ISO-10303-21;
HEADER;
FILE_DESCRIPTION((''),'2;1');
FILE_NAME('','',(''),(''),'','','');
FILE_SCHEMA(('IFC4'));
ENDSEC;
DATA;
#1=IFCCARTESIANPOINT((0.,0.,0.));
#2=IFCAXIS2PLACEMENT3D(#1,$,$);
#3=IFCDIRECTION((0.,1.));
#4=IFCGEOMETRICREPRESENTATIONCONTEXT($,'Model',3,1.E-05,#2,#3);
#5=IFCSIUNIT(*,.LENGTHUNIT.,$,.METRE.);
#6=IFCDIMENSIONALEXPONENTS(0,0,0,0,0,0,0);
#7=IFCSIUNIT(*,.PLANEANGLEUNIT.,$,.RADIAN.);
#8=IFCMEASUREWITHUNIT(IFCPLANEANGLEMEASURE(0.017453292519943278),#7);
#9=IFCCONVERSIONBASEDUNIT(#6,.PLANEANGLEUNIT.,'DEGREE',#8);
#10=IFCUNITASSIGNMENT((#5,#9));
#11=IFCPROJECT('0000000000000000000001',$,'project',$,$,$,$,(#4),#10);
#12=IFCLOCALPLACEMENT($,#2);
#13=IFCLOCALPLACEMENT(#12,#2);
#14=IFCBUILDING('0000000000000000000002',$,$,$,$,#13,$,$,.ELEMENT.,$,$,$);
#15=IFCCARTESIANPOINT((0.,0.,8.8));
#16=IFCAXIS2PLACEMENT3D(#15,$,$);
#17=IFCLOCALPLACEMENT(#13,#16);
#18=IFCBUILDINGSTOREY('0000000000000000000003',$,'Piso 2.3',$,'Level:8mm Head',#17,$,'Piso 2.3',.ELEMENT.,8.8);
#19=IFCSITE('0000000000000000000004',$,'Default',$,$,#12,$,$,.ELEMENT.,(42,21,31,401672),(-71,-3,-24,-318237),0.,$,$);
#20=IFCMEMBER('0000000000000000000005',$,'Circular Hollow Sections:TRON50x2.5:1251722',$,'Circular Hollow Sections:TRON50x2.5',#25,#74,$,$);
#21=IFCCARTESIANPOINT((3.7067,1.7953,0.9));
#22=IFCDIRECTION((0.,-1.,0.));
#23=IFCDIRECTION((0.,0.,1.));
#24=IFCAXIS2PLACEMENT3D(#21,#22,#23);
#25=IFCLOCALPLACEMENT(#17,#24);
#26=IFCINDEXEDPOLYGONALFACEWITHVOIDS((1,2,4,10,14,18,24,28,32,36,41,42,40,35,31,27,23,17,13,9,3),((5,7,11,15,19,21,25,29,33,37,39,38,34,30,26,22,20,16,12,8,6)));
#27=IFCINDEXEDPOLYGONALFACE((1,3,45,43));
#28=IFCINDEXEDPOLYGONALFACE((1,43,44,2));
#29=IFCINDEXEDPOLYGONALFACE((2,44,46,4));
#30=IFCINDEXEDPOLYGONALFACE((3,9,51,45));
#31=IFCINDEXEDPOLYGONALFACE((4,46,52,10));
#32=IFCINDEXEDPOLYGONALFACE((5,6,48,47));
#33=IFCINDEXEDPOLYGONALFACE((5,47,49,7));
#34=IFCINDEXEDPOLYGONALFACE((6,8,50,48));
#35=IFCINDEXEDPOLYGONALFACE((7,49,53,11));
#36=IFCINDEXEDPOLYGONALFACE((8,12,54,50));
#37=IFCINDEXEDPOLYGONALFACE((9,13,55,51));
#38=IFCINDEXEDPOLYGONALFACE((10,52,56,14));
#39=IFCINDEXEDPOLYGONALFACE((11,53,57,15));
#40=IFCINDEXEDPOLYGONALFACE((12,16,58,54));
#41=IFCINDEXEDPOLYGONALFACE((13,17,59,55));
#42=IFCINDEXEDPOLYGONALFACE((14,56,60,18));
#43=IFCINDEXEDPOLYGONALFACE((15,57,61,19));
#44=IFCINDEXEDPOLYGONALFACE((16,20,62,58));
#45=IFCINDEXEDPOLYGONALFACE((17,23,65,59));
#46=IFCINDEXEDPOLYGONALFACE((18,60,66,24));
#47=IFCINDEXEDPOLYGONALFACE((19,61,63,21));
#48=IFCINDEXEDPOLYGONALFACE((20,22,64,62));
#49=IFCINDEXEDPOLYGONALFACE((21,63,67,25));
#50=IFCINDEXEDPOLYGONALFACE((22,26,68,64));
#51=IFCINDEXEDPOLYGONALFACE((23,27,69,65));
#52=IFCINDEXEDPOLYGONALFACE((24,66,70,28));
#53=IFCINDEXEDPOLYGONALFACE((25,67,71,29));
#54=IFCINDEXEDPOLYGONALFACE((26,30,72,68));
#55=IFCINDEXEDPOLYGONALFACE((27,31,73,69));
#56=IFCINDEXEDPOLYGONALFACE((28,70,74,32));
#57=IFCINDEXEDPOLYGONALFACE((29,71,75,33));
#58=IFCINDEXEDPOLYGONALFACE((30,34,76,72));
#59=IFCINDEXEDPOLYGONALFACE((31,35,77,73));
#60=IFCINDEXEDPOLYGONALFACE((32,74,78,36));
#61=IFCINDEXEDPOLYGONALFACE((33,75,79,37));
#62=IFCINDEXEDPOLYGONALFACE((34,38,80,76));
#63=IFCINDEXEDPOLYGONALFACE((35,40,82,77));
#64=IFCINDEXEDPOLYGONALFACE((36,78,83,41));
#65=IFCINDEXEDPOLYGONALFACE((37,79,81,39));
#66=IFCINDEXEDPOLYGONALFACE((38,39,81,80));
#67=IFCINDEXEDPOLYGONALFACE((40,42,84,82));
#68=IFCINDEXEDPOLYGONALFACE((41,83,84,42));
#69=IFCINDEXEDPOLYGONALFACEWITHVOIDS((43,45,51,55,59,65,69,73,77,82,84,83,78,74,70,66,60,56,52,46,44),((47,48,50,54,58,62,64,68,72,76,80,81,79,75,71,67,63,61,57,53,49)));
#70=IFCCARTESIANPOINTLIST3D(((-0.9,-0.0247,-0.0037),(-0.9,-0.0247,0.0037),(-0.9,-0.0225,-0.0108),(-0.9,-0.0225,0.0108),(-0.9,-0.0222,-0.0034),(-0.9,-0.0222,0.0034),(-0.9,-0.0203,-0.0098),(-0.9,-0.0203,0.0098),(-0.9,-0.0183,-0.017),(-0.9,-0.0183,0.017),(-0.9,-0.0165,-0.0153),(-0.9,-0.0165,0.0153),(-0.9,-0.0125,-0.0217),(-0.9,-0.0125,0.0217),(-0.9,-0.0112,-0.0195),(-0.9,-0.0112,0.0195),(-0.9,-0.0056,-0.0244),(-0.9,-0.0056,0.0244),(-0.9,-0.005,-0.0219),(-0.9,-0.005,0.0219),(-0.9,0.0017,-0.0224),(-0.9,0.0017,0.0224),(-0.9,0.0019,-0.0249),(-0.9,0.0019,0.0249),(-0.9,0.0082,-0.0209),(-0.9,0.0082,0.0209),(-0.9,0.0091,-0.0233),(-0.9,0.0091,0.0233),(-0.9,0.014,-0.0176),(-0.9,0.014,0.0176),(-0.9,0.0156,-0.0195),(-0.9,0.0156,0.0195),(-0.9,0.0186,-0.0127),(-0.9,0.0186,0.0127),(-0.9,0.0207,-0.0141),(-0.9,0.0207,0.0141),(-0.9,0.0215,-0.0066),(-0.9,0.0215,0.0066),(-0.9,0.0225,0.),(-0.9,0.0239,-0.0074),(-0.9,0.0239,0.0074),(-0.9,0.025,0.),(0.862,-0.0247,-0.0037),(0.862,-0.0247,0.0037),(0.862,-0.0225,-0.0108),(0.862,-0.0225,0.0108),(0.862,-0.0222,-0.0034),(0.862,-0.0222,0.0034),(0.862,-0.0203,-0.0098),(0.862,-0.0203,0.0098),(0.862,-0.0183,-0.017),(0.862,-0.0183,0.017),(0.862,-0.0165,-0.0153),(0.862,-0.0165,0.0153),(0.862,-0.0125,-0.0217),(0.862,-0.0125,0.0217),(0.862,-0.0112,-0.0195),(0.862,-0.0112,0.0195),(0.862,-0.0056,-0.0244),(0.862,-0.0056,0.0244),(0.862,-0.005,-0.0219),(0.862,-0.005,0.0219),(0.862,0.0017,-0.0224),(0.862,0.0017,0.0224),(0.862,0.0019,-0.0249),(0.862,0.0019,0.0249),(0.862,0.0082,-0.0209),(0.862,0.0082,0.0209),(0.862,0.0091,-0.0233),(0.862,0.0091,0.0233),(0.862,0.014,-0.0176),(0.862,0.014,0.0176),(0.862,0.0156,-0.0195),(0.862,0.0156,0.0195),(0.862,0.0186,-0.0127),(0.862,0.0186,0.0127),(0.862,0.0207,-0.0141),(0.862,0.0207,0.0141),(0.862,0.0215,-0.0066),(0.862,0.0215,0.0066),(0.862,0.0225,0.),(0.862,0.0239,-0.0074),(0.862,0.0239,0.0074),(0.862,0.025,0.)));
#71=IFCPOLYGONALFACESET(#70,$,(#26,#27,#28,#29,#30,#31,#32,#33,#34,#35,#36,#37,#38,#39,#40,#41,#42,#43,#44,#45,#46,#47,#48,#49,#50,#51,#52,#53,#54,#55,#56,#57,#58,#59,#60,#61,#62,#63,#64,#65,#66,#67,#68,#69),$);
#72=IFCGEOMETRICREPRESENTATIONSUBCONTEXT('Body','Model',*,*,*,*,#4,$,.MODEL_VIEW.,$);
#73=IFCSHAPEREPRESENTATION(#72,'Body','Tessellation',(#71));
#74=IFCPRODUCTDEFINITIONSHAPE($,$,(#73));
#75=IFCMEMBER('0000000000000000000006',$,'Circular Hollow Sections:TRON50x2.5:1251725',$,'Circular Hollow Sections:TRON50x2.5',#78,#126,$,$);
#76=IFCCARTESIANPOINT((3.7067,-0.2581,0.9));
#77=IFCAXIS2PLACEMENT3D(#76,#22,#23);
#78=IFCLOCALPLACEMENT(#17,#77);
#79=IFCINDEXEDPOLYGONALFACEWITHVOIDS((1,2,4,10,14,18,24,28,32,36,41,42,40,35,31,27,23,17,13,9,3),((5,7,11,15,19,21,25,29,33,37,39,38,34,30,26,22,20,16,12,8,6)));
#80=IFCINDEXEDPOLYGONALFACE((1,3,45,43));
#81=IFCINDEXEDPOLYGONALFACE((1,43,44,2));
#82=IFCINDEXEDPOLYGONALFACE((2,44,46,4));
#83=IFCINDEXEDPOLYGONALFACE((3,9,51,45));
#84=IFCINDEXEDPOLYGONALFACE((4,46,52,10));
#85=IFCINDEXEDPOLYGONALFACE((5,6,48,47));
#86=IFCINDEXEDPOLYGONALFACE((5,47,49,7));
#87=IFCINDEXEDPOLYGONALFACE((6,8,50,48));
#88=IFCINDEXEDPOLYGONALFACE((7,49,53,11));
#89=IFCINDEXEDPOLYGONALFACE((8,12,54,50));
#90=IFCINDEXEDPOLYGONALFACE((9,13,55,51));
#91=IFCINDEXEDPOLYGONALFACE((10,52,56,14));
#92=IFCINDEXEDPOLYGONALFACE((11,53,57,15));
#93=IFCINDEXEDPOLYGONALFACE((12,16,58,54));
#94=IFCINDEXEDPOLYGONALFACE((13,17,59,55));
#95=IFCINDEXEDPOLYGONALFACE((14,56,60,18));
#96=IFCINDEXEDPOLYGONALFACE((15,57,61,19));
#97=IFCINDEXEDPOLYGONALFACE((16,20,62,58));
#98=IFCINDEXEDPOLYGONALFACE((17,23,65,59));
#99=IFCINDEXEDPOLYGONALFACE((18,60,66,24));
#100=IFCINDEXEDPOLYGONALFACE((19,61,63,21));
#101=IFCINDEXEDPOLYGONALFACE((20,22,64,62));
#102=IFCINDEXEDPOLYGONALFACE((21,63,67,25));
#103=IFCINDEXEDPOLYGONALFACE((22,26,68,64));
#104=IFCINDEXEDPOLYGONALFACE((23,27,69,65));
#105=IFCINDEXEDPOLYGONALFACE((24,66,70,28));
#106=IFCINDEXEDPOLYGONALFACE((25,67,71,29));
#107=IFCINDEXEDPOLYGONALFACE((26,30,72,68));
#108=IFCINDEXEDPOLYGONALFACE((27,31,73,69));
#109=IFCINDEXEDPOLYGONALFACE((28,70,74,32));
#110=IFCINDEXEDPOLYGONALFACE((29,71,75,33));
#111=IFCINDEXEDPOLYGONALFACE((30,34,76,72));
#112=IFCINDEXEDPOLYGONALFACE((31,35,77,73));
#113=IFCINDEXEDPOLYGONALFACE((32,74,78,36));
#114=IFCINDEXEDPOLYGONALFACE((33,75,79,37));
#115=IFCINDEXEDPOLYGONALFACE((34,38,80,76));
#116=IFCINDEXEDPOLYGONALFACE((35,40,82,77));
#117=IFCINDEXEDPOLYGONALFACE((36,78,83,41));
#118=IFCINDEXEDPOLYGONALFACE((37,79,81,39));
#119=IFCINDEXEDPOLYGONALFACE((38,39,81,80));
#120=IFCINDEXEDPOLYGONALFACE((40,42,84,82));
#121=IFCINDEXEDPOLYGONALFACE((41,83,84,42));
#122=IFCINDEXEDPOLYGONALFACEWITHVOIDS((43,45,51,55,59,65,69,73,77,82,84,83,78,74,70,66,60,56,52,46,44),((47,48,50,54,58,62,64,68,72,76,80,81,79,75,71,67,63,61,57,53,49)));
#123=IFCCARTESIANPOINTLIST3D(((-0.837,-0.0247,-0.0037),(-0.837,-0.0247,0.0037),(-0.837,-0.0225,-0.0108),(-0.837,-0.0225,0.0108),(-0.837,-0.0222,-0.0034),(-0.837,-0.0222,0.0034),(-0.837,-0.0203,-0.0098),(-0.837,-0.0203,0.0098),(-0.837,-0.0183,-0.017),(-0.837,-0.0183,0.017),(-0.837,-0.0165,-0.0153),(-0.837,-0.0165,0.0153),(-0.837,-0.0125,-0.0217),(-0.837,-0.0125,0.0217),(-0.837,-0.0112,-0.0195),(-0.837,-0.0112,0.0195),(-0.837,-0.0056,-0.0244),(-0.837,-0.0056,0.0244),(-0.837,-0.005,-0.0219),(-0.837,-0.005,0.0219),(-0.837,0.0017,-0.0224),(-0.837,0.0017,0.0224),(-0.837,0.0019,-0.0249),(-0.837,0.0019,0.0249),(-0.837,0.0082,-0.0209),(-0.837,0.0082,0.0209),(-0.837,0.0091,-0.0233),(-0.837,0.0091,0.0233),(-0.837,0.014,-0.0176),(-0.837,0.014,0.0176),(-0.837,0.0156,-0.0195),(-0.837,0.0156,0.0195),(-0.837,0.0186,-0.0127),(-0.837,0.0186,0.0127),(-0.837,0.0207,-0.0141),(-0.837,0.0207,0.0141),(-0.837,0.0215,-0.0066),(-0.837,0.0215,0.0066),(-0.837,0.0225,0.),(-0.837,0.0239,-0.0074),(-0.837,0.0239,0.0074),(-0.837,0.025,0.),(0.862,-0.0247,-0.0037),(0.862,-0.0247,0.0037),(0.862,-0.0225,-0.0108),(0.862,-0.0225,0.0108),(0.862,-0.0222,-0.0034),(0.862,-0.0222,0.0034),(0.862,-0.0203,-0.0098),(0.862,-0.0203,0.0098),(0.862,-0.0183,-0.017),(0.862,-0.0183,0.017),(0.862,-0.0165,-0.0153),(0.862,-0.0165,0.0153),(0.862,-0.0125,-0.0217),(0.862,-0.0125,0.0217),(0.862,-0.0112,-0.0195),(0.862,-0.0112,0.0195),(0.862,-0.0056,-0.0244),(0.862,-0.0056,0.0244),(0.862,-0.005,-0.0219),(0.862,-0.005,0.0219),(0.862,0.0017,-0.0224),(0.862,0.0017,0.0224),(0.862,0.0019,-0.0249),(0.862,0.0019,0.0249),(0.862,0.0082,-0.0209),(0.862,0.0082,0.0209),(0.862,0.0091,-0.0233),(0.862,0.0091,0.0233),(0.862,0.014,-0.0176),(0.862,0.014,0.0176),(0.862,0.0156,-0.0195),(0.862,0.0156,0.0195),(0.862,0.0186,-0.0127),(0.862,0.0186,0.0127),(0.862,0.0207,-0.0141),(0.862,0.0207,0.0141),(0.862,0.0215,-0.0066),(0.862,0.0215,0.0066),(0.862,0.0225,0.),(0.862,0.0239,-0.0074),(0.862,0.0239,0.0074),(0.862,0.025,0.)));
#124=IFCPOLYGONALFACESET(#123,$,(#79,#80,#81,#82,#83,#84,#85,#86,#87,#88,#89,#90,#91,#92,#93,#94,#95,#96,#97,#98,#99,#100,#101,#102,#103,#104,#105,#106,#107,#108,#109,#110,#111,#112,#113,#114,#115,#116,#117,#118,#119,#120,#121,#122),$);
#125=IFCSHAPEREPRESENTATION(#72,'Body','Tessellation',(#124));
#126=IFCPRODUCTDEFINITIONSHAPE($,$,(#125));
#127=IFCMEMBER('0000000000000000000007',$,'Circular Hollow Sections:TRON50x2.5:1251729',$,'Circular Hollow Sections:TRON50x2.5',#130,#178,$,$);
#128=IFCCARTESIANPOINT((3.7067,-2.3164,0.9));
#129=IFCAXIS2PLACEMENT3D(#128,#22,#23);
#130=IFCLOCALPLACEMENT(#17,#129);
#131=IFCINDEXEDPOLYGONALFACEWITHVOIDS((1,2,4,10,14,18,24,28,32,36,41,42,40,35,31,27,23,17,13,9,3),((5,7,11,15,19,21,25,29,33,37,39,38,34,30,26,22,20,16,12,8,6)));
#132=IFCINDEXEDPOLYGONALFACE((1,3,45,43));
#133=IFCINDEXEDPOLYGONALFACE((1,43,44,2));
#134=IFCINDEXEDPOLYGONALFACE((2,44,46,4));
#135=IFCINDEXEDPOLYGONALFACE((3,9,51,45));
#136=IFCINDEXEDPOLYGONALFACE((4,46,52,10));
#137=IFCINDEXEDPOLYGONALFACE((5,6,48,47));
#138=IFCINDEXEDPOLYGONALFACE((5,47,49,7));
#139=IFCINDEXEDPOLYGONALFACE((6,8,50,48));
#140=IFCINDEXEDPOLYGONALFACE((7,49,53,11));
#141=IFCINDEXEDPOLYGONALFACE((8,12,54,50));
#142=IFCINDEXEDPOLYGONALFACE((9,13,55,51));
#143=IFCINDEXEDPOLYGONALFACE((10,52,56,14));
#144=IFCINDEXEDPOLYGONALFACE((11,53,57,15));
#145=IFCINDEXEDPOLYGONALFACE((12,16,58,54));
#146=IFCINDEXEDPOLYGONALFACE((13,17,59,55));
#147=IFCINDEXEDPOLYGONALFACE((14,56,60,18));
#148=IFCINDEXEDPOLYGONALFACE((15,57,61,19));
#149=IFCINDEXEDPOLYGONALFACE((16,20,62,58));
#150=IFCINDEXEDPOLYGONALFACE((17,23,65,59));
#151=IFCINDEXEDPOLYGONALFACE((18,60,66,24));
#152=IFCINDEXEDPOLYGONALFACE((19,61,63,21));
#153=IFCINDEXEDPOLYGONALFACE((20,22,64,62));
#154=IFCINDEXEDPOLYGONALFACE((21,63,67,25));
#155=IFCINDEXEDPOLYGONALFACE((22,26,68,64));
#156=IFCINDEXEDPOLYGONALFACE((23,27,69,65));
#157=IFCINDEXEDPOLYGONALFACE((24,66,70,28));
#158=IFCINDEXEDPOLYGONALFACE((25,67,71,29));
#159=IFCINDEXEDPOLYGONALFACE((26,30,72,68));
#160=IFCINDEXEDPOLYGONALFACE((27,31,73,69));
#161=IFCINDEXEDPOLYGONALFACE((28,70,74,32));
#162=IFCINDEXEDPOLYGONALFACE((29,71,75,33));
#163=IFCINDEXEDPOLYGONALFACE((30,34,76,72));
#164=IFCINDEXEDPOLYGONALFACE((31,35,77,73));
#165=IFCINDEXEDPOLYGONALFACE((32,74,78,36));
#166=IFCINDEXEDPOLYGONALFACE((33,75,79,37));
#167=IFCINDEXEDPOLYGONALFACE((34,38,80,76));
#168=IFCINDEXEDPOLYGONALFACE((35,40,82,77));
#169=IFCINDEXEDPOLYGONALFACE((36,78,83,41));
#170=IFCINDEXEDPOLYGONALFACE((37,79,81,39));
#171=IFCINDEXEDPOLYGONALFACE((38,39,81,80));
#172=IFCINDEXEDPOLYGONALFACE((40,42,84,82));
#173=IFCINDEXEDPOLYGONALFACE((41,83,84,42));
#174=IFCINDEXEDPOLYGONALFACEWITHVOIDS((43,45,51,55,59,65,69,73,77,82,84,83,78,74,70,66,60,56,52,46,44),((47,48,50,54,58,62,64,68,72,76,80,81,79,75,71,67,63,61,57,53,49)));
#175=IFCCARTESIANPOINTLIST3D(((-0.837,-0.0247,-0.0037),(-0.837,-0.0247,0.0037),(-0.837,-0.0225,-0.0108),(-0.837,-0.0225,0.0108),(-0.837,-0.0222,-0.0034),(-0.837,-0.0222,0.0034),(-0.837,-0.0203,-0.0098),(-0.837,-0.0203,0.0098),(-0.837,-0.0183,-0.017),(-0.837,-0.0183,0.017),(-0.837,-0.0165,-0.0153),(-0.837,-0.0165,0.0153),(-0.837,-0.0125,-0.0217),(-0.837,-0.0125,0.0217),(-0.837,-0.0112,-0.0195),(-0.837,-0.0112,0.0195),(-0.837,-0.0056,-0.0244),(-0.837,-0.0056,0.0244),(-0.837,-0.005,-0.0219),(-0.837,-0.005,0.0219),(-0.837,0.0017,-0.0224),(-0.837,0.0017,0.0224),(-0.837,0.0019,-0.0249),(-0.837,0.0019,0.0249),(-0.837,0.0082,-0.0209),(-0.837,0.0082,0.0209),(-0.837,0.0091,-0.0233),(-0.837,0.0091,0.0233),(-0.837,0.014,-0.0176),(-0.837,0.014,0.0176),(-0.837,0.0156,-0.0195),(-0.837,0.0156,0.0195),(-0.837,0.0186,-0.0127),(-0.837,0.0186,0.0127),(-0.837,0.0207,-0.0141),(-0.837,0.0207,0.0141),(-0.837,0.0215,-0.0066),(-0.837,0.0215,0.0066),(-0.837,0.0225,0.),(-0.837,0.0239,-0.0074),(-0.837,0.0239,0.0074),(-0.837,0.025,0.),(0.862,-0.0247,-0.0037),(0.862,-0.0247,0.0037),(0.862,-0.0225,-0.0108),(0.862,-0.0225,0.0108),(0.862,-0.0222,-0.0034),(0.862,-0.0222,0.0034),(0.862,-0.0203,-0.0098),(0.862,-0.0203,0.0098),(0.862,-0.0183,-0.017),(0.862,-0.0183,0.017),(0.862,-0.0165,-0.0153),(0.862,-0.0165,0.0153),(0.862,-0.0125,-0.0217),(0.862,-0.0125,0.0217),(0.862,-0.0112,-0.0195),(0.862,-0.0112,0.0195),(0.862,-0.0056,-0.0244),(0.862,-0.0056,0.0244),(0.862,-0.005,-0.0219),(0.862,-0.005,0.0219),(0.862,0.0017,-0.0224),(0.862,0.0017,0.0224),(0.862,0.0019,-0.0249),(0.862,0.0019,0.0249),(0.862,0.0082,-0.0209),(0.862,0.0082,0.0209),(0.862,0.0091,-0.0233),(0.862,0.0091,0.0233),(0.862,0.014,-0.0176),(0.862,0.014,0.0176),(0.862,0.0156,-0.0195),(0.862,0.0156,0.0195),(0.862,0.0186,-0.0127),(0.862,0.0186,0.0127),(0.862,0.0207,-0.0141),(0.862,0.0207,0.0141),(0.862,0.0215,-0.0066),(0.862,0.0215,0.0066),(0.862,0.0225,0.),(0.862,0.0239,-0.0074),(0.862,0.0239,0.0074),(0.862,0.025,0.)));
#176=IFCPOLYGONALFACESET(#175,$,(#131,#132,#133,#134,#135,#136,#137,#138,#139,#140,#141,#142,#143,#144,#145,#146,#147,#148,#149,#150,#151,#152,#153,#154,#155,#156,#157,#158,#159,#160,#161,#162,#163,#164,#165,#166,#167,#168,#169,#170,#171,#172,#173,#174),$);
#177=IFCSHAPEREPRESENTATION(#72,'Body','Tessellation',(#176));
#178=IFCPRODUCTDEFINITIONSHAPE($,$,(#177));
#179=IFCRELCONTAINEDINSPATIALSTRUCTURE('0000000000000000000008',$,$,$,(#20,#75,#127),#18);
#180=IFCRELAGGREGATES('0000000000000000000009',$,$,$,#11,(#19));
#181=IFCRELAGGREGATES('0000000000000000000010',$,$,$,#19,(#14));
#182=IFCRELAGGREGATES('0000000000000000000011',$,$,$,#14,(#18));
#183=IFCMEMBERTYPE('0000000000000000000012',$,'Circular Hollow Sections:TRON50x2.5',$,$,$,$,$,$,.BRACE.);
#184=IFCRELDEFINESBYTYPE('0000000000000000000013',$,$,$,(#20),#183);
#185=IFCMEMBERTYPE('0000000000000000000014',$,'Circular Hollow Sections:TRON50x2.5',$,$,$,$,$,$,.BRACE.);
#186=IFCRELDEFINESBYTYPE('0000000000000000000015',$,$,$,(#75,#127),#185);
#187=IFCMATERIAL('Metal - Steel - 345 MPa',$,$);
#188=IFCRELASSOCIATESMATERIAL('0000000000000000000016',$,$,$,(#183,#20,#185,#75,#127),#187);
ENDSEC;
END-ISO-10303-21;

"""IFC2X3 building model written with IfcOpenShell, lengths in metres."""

from ifc_helpers import new_model, entity, si_unit, converted_unit, direction, frame, frame_2d, origin, place, context, subcontext, project, spatial, hollow_circle, extrude, source, transform, mapped, material, type_object, type_shapes, element, save


model = new_model("IFC2X3")

# Units and contexts
model_context = context("Model", 3, precision=1e-05, world=origin(), true_north=direction((0.0, 1.0)))
body_context = subcontext(model_context, "Body", "Model", "MODEL_VIEW")
ifc_project = project(units=[si_unit("LENGTHUNIT", "METRE"), converted_unit("PLANEANGLEUNIT", "DEGREE", entity("IfcPlaneAngleMeasure", 0.017453292519943278), si_unit("PLANEANGLEUNIT", "RADIAN"), dimensions=[0, 0, 0, 0, 0, 0, 0])], contexts=[model_context])

# Site, building, storey
site_placement = place(None, origin())
site = spatial("IfcSite", under=ifc_project, at=site_placement, Name="Default", CompositionType="ELEMENT", RefLatitude=(42, 21, 31, 401672), RefLongitude=(-71, -3, -24, -318237), RefElevation=0.0)
building_placement = place(site_placement, origin())
building = spatial("IfcBuilding", under=site, at=building_placement, CompositionType="ELEMENT")
storey_placement = place(building_placement, frame((0.0, 0.0, 8.8)))
storey = spatial("IfcBuildingStorey", under=building, at=storey_placement, Name="Piso 2.3", ObjectType="Level:8mm Head", LongName="Piso 2.3", CompositionType="ELEMENT", Elevation=8.8)

# Shared definitions
ifc_material_1 = material(Name="Metal - Steel - 345 MPa")

# Members
member_type_1 = type_object("IfcMemberType", Name="Circular Hollow Sections:TRON50x2.5", PredefinedType="BRACE", material=ifc_material_1)
shared_shape_1 = source(origin(), body_context, "Body", "SweptSolid", [
    extrude(hollow_circle(Radius=0.025, WallThickness=0.0025, at=frame_2d((0.0, 0.0), x_axis=(1.0, 0.0))), frame((-0.9, 0.0, 0.0), z_axis=(1.0, 0.0, 0.0), x_axis=(0.0, 1.0, 0.0)), (0.0, 0.0, 1.0), 1.762),
])
type_shapes(member_type_1, [shared_shape_1])
member_1_placement = place(storey_placement, frame((3.7067, 1.7953, 0.9), z_axis=(0.0, -1.0, 0.0), x_axis=(0.0, 0.0, 1.0)))
element("IfcMember", 1, at=member_1_placement, inside=storey, type_object=member_type_1, material=ifc_material_1, Name="Circular Hollow Sections:TRON50x2.5:1251722", ObjectType="Circular Hollow Sections:TRON50x2.5", context=body_context, shape_type="MappedRepresentation", body=[
    mapped(shared_shape_1, transform((0.0, 0.0, 0.0), scale=1.0)),
])
member_type_2 = type_object("IfcMemberType", Name="Circular Hollow Sections:TRON50x2.5", PredefinedType="BRACE", material=ifc_material_1)
shared_shape_2 = source(origin(), body_context, "Body", "SweptSolid", [
    extrude(hollow_circle(Radius=0.025, WallThickness=0.0025, at=frame_2d((0.0, 0.0), x_axis=(1.0, 0.0))), frame((-0.837, 0.0, 0.0), z_axis=(1.0, 0.0, 0.0), x_axis=(0.0, 1.0, 0.0)), (0.0, 0.0, 1.0), 1.699),
])
type_shapes(member_type_2, [shared_shape_2])
for number, where, z_axis, x_axis, name in (
    (2, (3.7067, -0.2581, 0.9), (0.0, -1.0, 0.0), (0.0, 0.0, 1.0), "Circular Hollow Sections:TRON50x2.5:1251725"),
    (3, (3.7067, -2.3164, 0.9), (0.0, -1.0, 0.0), (0.0, 0.0, 1.0), "Circular Hollow Sections:TRON50x2.5:1251729"),
):
    element("IfcMember", number, at=place(storey_placement, frame(where, z_axis=z_axis, x_axis=x_axis)), inside=storey, type_object=member_type_2, material=ifc_material_1, Name=name, ObjectType="Circular Hollow Sections:TRON50x2.5", context=body_context, shape_type="MappedRepresentation", body=[
        mapped(shared_shape_2, transform((0.0, 0.0, 0.0), scale=1.0)),
    ])

save(model, "model.ifc")
